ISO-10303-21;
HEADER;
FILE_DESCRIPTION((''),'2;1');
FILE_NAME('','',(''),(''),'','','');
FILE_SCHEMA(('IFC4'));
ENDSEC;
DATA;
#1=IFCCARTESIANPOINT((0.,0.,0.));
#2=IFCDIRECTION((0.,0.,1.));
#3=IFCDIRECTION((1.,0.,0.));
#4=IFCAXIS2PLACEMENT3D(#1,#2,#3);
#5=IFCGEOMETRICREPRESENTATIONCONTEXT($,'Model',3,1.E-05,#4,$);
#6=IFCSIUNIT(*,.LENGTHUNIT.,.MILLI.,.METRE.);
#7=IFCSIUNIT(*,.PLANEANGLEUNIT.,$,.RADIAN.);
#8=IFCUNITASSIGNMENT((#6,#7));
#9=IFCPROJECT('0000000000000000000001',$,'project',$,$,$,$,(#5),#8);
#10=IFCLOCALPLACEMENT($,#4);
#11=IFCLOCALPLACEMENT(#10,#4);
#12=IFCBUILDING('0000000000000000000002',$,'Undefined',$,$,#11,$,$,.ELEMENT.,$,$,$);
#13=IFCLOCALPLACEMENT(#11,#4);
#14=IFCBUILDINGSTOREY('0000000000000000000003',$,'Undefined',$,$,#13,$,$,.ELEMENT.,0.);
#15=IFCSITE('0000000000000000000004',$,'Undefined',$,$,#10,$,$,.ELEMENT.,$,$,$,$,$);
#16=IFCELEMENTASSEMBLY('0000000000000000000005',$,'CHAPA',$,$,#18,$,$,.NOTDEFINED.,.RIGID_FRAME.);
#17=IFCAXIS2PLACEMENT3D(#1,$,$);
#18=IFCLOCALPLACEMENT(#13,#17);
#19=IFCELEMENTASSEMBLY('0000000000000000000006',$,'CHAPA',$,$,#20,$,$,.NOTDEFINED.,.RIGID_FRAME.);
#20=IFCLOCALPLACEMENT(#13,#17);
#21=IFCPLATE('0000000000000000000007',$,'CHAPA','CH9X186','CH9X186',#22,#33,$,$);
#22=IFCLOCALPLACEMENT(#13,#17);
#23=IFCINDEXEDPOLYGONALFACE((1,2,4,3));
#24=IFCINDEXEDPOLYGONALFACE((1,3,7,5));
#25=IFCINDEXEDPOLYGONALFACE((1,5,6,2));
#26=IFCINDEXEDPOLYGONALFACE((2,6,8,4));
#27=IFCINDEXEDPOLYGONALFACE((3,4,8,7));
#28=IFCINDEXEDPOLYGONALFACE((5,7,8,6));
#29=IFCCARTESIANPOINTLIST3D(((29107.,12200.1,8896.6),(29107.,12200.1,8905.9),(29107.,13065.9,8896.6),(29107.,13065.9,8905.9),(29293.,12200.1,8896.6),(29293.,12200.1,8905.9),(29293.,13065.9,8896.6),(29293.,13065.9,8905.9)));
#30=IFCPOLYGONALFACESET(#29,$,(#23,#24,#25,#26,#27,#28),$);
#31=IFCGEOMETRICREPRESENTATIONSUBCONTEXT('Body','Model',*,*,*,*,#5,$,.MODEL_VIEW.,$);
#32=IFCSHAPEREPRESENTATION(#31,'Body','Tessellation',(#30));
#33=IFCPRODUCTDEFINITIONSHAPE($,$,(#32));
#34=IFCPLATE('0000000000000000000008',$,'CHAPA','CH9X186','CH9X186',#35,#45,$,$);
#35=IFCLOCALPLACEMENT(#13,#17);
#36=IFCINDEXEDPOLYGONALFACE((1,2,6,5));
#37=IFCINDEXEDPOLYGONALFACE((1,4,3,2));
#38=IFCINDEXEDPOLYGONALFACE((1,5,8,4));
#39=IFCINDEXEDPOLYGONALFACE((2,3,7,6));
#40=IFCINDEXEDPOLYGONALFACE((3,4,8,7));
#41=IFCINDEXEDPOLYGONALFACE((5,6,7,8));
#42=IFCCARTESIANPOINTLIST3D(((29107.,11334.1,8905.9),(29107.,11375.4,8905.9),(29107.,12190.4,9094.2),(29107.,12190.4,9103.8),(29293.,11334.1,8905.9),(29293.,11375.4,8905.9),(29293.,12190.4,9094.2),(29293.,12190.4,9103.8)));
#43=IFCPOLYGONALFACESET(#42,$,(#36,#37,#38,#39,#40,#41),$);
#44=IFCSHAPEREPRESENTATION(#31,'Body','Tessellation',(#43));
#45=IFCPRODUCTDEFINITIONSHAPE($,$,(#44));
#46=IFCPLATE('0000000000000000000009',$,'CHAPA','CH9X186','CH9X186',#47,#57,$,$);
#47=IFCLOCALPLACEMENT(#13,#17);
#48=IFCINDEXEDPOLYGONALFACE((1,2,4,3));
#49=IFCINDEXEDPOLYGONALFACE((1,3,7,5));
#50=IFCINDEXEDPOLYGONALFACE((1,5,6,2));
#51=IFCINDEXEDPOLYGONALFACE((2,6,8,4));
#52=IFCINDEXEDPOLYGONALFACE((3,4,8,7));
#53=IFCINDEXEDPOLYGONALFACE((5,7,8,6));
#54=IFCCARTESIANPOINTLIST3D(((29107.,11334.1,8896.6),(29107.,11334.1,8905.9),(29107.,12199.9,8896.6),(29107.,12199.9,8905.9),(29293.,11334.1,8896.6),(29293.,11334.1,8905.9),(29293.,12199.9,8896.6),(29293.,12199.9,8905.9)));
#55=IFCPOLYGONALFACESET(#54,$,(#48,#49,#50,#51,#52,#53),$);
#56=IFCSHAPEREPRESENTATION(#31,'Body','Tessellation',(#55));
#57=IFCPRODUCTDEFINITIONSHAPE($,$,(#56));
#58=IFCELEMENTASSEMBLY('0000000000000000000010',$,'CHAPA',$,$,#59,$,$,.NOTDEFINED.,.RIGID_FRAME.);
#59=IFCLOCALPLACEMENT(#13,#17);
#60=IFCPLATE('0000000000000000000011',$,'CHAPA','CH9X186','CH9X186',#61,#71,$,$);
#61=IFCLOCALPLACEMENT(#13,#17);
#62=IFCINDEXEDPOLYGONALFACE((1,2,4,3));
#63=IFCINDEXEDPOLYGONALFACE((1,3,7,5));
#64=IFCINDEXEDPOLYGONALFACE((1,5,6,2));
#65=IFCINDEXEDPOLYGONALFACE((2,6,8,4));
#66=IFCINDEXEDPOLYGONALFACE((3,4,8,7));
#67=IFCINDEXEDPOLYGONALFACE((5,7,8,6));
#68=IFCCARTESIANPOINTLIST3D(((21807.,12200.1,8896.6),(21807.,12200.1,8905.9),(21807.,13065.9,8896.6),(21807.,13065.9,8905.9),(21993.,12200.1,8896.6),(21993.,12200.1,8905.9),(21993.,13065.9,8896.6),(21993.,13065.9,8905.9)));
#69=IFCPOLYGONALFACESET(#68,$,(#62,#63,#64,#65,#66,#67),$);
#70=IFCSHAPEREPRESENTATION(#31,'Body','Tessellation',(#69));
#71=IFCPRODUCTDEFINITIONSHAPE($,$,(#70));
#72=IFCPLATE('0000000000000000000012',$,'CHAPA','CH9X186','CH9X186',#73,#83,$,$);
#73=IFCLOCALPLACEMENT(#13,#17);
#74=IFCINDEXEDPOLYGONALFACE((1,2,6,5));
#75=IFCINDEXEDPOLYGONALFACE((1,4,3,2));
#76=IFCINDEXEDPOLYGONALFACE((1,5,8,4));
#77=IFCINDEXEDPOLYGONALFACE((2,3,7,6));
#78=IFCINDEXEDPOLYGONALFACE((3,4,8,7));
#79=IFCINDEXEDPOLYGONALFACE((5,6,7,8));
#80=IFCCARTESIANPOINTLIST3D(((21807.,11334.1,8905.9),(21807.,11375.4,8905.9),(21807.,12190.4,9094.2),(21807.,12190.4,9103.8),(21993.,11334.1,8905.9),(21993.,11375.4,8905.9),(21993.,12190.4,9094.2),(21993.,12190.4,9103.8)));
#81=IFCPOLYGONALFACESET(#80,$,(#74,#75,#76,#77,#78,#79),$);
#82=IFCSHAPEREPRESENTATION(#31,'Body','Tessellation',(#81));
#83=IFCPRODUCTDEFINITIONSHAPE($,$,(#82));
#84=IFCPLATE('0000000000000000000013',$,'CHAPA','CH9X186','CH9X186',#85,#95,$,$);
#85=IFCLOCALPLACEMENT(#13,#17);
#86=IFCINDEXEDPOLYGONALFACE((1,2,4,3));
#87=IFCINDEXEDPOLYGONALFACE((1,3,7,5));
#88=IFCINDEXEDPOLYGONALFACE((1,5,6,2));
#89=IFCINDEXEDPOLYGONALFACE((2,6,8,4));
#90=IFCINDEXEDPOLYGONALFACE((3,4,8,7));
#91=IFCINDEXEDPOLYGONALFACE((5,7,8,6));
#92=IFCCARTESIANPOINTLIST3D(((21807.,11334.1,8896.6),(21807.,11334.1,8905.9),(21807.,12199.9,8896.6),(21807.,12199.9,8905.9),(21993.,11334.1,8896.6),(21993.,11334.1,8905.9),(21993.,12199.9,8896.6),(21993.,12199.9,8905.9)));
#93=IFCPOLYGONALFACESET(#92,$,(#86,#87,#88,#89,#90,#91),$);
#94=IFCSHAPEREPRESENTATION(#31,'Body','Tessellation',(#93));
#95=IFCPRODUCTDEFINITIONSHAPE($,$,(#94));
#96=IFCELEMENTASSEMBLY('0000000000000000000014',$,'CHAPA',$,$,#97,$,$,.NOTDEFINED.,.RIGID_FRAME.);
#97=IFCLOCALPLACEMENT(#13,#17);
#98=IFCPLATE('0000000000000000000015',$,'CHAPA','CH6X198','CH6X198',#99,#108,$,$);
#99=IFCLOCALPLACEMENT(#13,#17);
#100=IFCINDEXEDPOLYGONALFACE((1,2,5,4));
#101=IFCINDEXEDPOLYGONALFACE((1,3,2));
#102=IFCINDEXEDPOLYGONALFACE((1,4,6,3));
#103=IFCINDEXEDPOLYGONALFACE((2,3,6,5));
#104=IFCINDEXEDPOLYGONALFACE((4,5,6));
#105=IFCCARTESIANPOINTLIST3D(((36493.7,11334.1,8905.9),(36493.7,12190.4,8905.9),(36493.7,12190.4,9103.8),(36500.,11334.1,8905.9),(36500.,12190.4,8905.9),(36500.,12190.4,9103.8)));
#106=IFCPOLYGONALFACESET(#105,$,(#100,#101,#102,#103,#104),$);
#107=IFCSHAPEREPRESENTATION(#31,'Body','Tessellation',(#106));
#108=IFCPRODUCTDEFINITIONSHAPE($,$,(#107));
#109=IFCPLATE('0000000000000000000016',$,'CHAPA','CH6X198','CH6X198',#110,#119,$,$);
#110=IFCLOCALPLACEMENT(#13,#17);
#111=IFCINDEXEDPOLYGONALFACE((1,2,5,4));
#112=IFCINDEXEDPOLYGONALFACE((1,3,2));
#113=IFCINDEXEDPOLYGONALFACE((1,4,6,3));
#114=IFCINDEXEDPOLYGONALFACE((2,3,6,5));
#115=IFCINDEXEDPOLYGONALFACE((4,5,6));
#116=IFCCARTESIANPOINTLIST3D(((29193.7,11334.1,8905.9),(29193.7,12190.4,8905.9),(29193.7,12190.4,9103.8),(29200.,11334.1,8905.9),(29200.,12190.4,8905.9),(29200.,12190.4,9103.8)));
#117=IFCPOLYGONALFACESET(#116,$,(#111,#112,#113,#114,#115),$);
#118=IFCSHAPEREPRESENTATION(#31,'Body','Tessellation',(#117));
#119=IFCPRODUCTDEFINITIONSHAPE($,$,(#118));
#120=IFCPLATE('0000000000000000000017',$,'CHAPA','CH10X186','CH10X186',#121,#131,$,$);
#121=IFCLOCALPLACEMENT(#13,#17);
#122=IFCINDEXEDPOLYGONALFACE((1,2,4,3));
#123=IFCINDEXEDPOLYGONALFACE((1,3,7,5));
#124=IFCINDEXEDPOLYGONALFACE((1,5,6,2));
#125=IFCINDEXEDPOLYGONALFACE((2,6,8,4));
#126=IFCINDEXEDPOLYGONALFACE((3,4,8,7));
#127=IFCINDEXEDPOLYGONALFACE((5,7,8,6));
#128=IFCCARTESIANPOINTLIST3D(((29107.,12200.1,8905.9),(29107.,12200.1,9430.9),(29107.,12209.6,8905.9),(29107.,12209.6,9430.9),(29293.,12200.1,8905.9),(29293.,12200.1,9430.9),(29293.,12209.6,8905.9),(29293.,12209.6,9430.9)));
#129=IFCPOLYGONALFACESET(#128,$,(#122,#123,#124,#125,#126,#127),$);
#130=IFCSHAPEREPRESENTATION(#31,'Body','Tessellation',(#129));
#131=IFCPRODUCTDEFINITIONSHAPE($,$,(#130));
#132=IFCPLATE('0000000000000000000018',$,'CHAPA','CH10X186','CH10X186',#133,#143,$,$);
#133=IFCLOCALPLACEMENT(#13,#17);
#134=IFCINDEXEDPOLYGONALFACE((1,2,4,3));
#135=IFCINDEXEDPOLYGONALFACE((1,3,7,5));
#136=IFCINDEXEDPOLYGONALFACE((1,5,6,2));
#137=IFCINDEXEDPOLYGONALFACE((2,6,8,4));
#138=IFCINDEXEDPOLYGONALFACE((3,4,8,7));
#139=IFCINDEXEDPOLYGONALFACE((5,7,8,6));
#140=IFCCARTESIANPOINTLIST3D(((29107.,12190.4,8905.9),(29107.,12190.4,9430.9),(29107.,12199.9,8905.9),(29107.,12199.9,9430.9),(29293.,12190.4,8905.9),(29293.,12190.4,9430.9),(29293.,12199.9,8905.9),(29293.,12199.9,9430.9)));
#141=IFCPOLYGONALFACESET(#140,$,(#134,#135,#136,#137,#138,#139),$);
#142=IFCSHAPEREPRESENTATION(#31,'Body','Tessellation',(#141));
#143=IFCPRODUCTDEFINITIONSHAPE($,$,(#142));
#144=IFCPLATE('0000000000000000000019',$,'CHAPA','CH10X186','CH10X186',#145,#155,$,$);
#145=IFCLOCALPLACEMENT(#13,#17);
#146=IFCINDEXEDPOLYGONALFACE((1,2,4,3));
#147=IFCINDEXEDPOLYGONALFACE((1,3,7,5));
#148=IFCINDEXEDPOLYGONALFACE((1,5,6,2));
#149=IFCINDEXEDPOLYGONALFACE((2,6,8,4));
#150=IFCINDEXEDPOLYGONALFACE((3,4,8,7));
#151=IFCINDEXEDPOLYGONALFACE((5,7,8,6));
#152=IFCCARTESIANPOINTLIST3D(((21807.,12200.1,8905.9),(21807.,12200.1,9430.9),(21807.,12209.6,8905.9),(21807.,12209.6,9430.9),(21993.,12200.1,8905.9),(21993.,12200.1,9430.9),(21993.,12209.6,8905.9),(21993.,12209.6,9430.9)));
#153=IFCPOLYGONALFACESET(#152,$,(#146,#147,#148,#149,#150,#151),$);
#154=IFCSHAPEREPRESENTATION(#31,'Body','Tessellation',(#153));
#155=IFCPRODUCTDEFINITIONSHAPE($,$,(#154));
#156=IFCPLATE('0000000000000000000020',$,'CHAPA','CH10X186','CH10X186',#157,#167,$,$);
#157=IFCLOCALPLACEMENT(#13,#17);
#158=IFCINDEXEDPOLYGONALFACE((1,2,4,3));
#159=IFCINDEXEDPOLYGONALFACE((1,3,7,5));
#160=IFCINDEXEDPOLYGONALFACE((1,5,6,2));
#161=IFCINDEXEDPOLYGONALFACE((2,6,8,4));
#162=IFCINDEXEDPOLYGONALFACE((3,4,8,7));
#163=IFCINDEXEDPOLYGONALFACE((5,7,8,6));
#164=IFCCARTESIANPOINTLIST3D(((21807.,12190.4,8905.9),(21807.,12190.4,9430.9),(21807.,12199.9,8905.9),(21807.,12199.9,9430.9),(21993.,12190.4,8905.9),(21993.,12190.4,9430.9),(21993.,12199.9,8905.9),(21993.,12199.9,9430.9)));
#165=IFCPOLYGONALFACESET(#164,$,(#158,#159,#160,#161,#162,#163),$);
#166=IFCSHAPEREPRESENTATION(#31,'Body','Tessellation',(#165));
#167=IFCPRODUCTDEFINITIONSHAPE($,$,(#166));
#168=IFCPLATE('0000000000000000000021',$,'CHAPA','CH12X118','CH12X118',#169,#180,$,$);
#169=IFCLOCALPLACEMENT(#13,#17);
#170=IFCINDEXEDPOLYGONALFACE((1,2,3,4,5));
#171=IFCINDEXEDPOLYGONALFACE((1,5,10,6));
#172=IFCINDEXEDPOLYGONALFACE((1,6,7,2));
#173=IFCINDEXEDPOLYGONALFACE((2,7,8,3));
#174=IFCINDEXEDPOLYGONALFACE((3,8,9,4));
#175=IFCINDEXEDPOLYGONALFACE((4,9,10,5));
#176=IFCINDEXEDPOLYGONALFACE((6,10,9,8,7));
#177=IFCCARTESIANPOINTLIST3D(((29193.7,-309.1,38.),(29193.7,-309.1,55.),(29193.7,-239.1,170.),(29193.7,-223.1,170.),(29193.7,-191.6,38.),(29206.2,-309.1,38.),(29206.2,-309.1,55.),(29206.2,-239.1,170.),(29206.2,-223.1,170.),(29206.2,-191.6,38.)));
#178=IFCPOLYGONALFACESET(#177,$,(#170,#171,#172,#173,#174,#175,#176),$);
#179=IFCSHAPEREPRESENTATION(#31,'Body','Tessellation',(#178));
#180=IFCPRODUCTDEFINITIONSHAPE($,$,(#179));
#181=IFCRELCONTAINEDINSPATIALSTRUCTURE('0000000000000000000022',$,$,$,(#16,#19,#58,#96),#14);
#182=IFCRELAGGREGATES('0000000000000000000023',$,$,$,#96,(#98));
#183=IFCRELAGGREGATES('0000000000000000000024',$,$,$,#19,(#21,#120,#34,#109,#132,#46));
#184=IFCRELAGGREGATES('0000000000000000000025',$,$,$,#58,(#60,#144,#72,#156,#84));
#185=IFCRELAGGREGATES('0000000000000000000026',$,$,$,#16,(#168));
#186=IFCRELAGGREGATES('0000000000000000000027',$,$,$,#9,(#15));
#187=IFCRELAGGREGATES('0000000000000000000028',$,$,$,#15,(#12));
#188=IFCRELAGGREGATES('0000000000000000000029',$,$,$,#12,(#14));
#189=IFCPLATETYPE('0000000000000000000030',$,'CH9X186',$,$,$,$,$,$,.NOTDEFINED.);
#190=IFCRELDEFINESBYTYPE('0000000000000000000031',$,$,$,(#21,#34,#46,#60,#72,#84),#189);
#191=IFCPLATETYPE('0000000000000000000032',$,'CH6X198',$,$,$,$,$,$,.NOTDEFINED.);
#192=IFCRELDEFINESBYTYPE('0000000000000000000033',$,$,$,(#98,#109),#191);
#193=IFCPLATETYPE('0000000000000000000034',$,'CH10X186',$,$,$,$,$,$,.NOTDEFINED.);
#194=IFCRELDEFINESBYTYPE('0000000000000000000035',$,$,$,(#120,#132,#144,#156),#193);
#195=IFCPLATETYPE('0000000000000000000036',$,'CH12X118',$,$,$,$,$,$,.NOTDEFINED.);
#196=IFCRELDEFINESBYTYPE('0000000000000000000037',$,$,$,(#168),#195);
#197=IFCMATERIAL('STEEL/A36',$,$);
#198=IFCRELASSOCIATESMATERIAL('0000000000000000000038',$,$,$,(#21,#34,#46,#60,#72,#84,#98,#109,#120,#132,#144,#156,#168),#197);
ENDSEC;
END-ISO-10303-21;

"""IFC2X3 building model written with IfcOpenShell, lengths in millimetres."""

from ifc_helpers import new_model, si_unit, frame, origin_with_axes, place, context, subcontext, project, spatial, polyline, outline, extrude, clip, halfspace, material, type_object, element, aggregate, save


model = new_model("IFC2X3")

# Units and contexts
model_context = context("Model", 3, precision=1e-05, world=origin_with_axes())
body_context = subcontext(model_context, "Body", "Model", "MODEL_VIEW")
ifc_project = project(units=[si_unit("LENGTHUNIT", "METRE", prefix="MILLI"), si_unit("PLANEANGLEUNIT", "RADIAN")], contexts=[model_context])

# Site, building, storey
site_placement = place(None, origin_with_axes())
site = spatial("IfcSite", under=ifc_project, at=site_placement, Name="Undefined", CompositionType="ELEMENT")
building_placement = place(site_placement, origin_with_axes())
building = spatial("IfcBuilding", under=site, at=building_placement, Name="Undefined", CompositionType="ELEMENT")
storey_placement = place(building_placement, origin_with_axes())
storey = spatial("IfcBuildingStorey", under=building, at=storey_placement, Name="Undefined", CompositionType="ELEMENT", Elevation=0.0)

# Element assembly
assembly_1_placement = place(storey_placement, origin_with_axes())
assembly_1 = element("IfcElementAssembly", 1, at=assembly_1_placement, inside=storey, Name="CHAPA", AssemblyPlace="NOTDEFINED", PredefinedType="RIGID_FRAME")

# Shared definitions
ifc_material_1 = material(Name="STEEL/A36")

# Element assemblies, plates
assembly_2_placement = place(storey_placement, origin_with_axes())
assembly_2 = element("IfcElementAssembly", 2, at=assembly_2_placement, inside=storey, Name="CHAPA", AssemblyPlace="NOTDEFINED", PredefinedType="RIGID_FRAME")
plate_type_1 = type_object("IfcPlateType", Name="CH9X186", PredefinedType="NOTDEFINED")
plate_1_placement = place(assembly_2_placement, frame((29293.0, 12200.1, 8901.3), z_axis=(0.0, 0.0, -1.0), x_axis=(-1.0, 0.0, 0.0)))
plate_1 = element("IfcPlate", 3, at=plate_1_placement, type_object=plate_type_1, material=ifc_material_1, Name="CHAPA", Description="CH9X186", ObjectType="CH9X186", context=body_context, shape_type="SweptSolid", body=[
    extrude(outline(polyline([(0.0, 0.0), (186.0, 0.0), (186.0, 865.8), (0.0, 865.8), (0.0, 0.0)])), frame((0.0, 0.0, -4.7), z_axis=(0.0, 0.0, 1.0), x_axis=(1.0, 0.0, 0.0)), (0.0, 0.0, 1.0), 9.3),
])
plate_2_placement = place(assembly_2_placement, frame((29293.0, 12191.4, 9099.3), z_axis=(0.0, -0.225125, 0.97433), x_axis=(-1.0, 0.0, 0.0)))
plate_2 = element("IfcPlate", 4, at=plate_2_placement, type_object=plate_type_1, material=ifc_material_1, Name="CHAPA", Description="CH9X186", ObjectType="CH9X186", context=body_context, shape_type="Clipping", body=[
    clip(clip(extrude(outline(polyline([(0.0, 0.0), (186.0, 0.0), (186.0, 878.9), (0.0, 878.9), (0.0, 0.0)])), frame((0.0, 0.0, -4.7), z_axis=(0.0, 0.0, 1.0), x_axis=(1.0, 0.0, 0.0)), (0.0, 0.0, 1.0), 9.3), halfspace(frame((186.0, -500.0, -314.0), z_axis=(0.0, 0.225128, -0.974329), x_axis=(0.0, 0.974329, 0.225128)), False)), halfspace(frame((0.0, 2.1, -4.6), z_axis=(0.0, -0.97433, -0.225125), x_axis=(0.0, -0.225125, 0.97433)), False)),
])
plate_3_placement = place(assembly_2_placement, frame((29293.0, 12199.9, 8901.3), z_axis=(0.0, 0.0, 1.0), x_axis=(-1.0, 0.0, 0.0)))
plate_3 = element("IfcPlate", 5, at=plate_3_placement, type_object=plate_type_1, material=ifc_material_1, Name="CHAPA", Description="CH9X186", ObjectType="CH9X186", context=body_context, shape_type="SweptSolid", body=[
    extrude(outline(polyline([(0.0, 0.0), (186.0, 0.0), (186.0, 865.8), (0.0, 865.8), (0.0, 0.0)])), frame((0.0, 0.0, -4.7), z_axis=(0.0, 0.0, 1.0), x_axis=(1.0, 0.0, 0.0)), (0.0, 0.0, 1.0), 9.3),
])
assembly_3_placement = place(storey_placement, origin_with_axes())
assembly_3 = element("IfcElementAssembly", 6, at=assembly_3_placement, inside=storey, Name="CHAPA", AssemblyPlace="NOTDEFINED", PredefinedType="RIGID_FRAME")
plate_4_placement = place(assembly_3_placement, frame((21993.0, 12200.1, 8901.3), z_axis=(0.0, 0.0, -1.0), x_axis=(-1.0, 0.0, 0.0)))
plate_4 = element("IfcPlate", 7, at=plate_4_placement, type_object=plate_type_1, material=ifc_material_1, Name="CHAPA", Description="CH9X186", ObjectType="CH9X186", context=body_context, shape_type="SweptSolid", body=[
    extrude(outline(polyline([(0.0, 0.0), (186.0, 0.0), (186.0, 865.8), (0.0, 865.8), (0.0, 0.0)])), frame((0.0, 0.0, -4.7), z_axis=(0.0, 0.0, 1.0), x_axis=(1.0, 0.0, 0.0)), (0.0, 0.0, 1.0), 9.3),
])
plate_5_placement = place(assembly_3_placement, frame((21993.0, 12191.4, 9099.3), z_axis=(0.0, -0.225125, 0.97433), x_axis=(-1.0, 0.0, 0.0)))
plate_5 = element("IfcPlate", 8, at=plate_5_placement, type_object=plate_type_1, material=ifc_material_1, Name="CHAPA", Description="CH9X186", ObjectType="CH9X186", context=body_context, shape_type="Clipping", body=[
    clip(clip(extrude(outline(polyline([(0.0, 0.0), (186.0, 0.0), (186.0, 878.9), (0.0, 878.9), (0.0, 0.0)])), frame((0.0, 0.0, -4.7), z_axis=(0.0, 0.0, 1.0), x_axis=(1.0, 0.0, 0.0)), (0.0, 0.0, 1.0), 9.3), halfspace(frame((186.0, -500.0, -314.0), z_axis=(0.0, 0.225128, -0.974329), x_axis=(0.0, 0.974329, 0.225128)), False)), halfspace(frame((0.0, 2.1, -4.6), z_axis=(0.0, -0.97433, -0.225125), x_axis=(0.0, -0.225125, 0.97433)), False)),
])
plate_6_placement = place(assembly_3_placement, frame((21993.0, 12199.9, 8901.3), z_axis=(0.0, 0.0, 1.0), x_axis=(-1.0, 0.0, 0.0)))
plate_6 = element("IfcPlate", 9, at=plate_6_placement, type_object=plate_type_1, material=ifc_material_1, Name="CHAPA", Description="CH9X186", ObjectType="CH9X186", context=body_context, shape_type="SweptSolid", body=[
    extrude(outline(polyline([(0.0, 0.0), (186.0, 0.0), (186.0, 865.8), (0.0, 865.8), (0.0, 0.0)])), frame((0.0, 0.0, -4.7), z_axis=(0.0, 0.0, 1.0), x_axis=(1.0, 0.0, 0.0)), (0.0, 0.0, 1.0), 9.3),
])

# Element assembly, plate
assembly_4_placement = place(storey_placement, origin_with_axes())
assembly_4 = element("IfcElementAssembly", 10, at=assembly_4_placement, inside=storey, Name="CHAPA", AssemblyPlace="NOTDEFINED", PredefinedType="RIGID_FRAME")
plate_type_2 = type_object("IfcPlateType", Name="CH6X198", PredefinedType="NOTDEFINED")
plate_7_placement = place(assembly_4_placement, frame((36496.8, 11334.1, 8905.9), z_axis=(1.0, 0.0, 0.0), x_axis=(0.0, 1.0, 0.0)))
plate_7 = element("IfcPlate", 11, at=plate_7_placement, type_object=plate_type_2, material=ifc_material_1, Name="CHAPA", Description="CH6X198", ObjectType="CH6X198", context=body_context, shape_type="SweptSolid", body=[
    extrude(outline(polyline([(0.0, 0.0), (856.3, 0.0), (856.3, 197.9), (0.0, 0.0)])), frame((0.0, 0.0, -3.1), z_axis=(0.0, 0.0, 1.0), x_axis=(1.0, 0.0, 0.0)), (0.0, 0.0, 1.0), 6.3),
])
aggregate(assembly_4, [plate_7])

# Plates
plate_8_placement = place(assembly_2_placement, frame((29196.8, 11334.1, 8905.9), z_axis=(1.0, 0.0, 0.0), x_axis=(0.0, 1.0, 0.0)))
plate_8 = element("IfcPlate", 12, at=plate_8_placement, type_object=plate_type_2, material=ifc_material_1, Name="CHAPA", Description="CH6X198", ObjectType="CH6X198", context=body_context, shape_type="SweptSolid", body=[
    extrude(outline(polyline([(0.0, 0.0), (856.3, 0.0), (856.3, 197.9), (0.0, 0.0)])), frame((0.0, 0.0, -3.1), z_axis=(0.0, 0.0, 1.0), x_axis=(1.0, 0.0, 0.0)), (0.0, 0.0, 1.0), 6.3),
])
plate_type_3 = type_object("IfcPlateType", Name="CH10X186", PredefinedType="NOTDEFINED")
plate_9_placement = place(assembly_2_placement, frame((29293.0, 12204.8, 9430.9), z_axis=(0.0, -1.0, 0.0), x_axis=(-1.0, 0.0, 0.0)))
plate_9 = element("IfcPlate", 13, at=plate_9_placement, type_object=plate_type_3, material=ifc_material_1, Name="CHAPA", Description="CH10X186", ObjectType="CH10X186", context=body_context, shape_type="SweptSolid", body=[
    extrude(outline(polyline([(0.0, 0.0), (186.0, 0.0), (186.0, 525.0), (0.0, 525.0), (0.0, 0.0)])), frame((0.0, 0.0, -4.8), z_axis=(0.0, 0.0, 1.0), x_axis=(1.0, 0.0, 0.0)), (0.0, 0.0, 1.0), 9.5),
])
plate_10_placement = place(assembly_2_placement, frame((29293.0, 12195.2, 9430.9), z_axis=(0.0, -1.0, 0.0), x_axis=(-1.0, 0.0, 0.0)))
plate_10 = element("IfcPlate", 14, at=plate_10_placement, type_object=plate_type_3, material=ifc_material_1, Name="CHAPA", Description="CH10X186", ObjectType="CH10X186", context=body_context, shape_type="SweptSolid", body=[
    extrude(outline(polyline([(0.0, 0.0), (186.0, 0.0), (186.0, 525.0), (0.0, 525.0), (0.0, 0.0)])), frame((0.0, 0.0, -4.8), z_axis=(0.0, 0.0, 1.0), x_axis=(1.0, 0.0, 0.0)), (0.0, 0.0, 1.0), 9.5),
])
aggregate(assembly_2, [plate_1, plate_9, plate_2, plate_8, plate_10, plate_3])
plate_11_placement = place(assembly_3_placement, frame((21993.0, 12204.8, 9430.9), z_axis=(0.0, -1.0, 0.0), x_axis=(-1.0, 0.0, 0.0)))
plate_11 = element("IfcPlate", 15, at=plate_11_placement, type_object=plate_type_3, material=ifc_material_1, Name="CHAPA", Description="CH10X186", ObjectType="CH10X186", context=body_context, shape_type="SweptSolid", body=[
    extrude(outline(polyline([(0.0, 0.0), (186.0, 0.0), (186.0, 525.0), (0.0, 525.0), (0.0, 0.0)])), frame((0.0, 0.0, -4.8), z_axis=(0.0, 0.0, 1.0), x_axis=(1.0, 0.0, 0.0)), (0.0, 0.0, 1.0), 9.5),
])
plate_12_placement = place(assembly_3_placement, frame((21993.0, 12195.2, 9430.9), z_axis=(0.0, -1.0, 0.0), x_axis=(-1.0, 0.0, 0.0)))
plate_12 = element("IfcPlate", 16, at=plate_12_placement, type_object=plate_type_3, material=ifc_material_1, Name="CHAPA", Description="CH10X186", ObjectType="CH10X186", context=body_context, shape_type="SweptSolid", body=[
    extrude(outline(polyline([(0.0, 0.0), (186.0, 0.0), (186.0, 525.0), (0.0, 525.0), (0.0, 0.0)])), frame((0.0, 0.0, -4.8), z_axis=(0.0, 0.0, 1.0), x_axis=(1.0, 0.0, 0.0)), (0.0, 0.0, 1.0), 9.5),
])
aggregate(assembly_3, [plate_4, plate_11, plate_5, plate_12, plate_6])
plate_type_4 = type_object("IfcPlateType", Name="CH12X118", PredefinedType="NOTDEFINED")
plate_13_placement = place(assembly_1_placement, frame((29200.0, -309.1, 38.0), z_axis=(1.0, 0.0, 0.0), x_axis=(0.0, 1.0, 0.0)))
plate_13 = element("IfcPlate", 17, at=plate_13_placement, type_object=plate_type_4, material=ifc_material_1, Name="CHAPA", Description="CH12X118", ObjectType="CH12X118", context=body_context, shape_type="SweptSolid", body=[
    extrude(outline(polyline([(0.0, 0.0), (117.5, 0.0), (85.9, 132.0), (70.0, 132.0), (0.0, 17.0), (0.0, 0.0)])), frame((0.0, 0.0, -6.2), z_axis=(0.0, 0.0, 1.0), x_axis=(1.0, 0.0, 0.0)), (0.0, 0.0, 1.0), 12.5),
])

aggregate(assembly_1, [plate_13])

save(model, "model.ifc")
